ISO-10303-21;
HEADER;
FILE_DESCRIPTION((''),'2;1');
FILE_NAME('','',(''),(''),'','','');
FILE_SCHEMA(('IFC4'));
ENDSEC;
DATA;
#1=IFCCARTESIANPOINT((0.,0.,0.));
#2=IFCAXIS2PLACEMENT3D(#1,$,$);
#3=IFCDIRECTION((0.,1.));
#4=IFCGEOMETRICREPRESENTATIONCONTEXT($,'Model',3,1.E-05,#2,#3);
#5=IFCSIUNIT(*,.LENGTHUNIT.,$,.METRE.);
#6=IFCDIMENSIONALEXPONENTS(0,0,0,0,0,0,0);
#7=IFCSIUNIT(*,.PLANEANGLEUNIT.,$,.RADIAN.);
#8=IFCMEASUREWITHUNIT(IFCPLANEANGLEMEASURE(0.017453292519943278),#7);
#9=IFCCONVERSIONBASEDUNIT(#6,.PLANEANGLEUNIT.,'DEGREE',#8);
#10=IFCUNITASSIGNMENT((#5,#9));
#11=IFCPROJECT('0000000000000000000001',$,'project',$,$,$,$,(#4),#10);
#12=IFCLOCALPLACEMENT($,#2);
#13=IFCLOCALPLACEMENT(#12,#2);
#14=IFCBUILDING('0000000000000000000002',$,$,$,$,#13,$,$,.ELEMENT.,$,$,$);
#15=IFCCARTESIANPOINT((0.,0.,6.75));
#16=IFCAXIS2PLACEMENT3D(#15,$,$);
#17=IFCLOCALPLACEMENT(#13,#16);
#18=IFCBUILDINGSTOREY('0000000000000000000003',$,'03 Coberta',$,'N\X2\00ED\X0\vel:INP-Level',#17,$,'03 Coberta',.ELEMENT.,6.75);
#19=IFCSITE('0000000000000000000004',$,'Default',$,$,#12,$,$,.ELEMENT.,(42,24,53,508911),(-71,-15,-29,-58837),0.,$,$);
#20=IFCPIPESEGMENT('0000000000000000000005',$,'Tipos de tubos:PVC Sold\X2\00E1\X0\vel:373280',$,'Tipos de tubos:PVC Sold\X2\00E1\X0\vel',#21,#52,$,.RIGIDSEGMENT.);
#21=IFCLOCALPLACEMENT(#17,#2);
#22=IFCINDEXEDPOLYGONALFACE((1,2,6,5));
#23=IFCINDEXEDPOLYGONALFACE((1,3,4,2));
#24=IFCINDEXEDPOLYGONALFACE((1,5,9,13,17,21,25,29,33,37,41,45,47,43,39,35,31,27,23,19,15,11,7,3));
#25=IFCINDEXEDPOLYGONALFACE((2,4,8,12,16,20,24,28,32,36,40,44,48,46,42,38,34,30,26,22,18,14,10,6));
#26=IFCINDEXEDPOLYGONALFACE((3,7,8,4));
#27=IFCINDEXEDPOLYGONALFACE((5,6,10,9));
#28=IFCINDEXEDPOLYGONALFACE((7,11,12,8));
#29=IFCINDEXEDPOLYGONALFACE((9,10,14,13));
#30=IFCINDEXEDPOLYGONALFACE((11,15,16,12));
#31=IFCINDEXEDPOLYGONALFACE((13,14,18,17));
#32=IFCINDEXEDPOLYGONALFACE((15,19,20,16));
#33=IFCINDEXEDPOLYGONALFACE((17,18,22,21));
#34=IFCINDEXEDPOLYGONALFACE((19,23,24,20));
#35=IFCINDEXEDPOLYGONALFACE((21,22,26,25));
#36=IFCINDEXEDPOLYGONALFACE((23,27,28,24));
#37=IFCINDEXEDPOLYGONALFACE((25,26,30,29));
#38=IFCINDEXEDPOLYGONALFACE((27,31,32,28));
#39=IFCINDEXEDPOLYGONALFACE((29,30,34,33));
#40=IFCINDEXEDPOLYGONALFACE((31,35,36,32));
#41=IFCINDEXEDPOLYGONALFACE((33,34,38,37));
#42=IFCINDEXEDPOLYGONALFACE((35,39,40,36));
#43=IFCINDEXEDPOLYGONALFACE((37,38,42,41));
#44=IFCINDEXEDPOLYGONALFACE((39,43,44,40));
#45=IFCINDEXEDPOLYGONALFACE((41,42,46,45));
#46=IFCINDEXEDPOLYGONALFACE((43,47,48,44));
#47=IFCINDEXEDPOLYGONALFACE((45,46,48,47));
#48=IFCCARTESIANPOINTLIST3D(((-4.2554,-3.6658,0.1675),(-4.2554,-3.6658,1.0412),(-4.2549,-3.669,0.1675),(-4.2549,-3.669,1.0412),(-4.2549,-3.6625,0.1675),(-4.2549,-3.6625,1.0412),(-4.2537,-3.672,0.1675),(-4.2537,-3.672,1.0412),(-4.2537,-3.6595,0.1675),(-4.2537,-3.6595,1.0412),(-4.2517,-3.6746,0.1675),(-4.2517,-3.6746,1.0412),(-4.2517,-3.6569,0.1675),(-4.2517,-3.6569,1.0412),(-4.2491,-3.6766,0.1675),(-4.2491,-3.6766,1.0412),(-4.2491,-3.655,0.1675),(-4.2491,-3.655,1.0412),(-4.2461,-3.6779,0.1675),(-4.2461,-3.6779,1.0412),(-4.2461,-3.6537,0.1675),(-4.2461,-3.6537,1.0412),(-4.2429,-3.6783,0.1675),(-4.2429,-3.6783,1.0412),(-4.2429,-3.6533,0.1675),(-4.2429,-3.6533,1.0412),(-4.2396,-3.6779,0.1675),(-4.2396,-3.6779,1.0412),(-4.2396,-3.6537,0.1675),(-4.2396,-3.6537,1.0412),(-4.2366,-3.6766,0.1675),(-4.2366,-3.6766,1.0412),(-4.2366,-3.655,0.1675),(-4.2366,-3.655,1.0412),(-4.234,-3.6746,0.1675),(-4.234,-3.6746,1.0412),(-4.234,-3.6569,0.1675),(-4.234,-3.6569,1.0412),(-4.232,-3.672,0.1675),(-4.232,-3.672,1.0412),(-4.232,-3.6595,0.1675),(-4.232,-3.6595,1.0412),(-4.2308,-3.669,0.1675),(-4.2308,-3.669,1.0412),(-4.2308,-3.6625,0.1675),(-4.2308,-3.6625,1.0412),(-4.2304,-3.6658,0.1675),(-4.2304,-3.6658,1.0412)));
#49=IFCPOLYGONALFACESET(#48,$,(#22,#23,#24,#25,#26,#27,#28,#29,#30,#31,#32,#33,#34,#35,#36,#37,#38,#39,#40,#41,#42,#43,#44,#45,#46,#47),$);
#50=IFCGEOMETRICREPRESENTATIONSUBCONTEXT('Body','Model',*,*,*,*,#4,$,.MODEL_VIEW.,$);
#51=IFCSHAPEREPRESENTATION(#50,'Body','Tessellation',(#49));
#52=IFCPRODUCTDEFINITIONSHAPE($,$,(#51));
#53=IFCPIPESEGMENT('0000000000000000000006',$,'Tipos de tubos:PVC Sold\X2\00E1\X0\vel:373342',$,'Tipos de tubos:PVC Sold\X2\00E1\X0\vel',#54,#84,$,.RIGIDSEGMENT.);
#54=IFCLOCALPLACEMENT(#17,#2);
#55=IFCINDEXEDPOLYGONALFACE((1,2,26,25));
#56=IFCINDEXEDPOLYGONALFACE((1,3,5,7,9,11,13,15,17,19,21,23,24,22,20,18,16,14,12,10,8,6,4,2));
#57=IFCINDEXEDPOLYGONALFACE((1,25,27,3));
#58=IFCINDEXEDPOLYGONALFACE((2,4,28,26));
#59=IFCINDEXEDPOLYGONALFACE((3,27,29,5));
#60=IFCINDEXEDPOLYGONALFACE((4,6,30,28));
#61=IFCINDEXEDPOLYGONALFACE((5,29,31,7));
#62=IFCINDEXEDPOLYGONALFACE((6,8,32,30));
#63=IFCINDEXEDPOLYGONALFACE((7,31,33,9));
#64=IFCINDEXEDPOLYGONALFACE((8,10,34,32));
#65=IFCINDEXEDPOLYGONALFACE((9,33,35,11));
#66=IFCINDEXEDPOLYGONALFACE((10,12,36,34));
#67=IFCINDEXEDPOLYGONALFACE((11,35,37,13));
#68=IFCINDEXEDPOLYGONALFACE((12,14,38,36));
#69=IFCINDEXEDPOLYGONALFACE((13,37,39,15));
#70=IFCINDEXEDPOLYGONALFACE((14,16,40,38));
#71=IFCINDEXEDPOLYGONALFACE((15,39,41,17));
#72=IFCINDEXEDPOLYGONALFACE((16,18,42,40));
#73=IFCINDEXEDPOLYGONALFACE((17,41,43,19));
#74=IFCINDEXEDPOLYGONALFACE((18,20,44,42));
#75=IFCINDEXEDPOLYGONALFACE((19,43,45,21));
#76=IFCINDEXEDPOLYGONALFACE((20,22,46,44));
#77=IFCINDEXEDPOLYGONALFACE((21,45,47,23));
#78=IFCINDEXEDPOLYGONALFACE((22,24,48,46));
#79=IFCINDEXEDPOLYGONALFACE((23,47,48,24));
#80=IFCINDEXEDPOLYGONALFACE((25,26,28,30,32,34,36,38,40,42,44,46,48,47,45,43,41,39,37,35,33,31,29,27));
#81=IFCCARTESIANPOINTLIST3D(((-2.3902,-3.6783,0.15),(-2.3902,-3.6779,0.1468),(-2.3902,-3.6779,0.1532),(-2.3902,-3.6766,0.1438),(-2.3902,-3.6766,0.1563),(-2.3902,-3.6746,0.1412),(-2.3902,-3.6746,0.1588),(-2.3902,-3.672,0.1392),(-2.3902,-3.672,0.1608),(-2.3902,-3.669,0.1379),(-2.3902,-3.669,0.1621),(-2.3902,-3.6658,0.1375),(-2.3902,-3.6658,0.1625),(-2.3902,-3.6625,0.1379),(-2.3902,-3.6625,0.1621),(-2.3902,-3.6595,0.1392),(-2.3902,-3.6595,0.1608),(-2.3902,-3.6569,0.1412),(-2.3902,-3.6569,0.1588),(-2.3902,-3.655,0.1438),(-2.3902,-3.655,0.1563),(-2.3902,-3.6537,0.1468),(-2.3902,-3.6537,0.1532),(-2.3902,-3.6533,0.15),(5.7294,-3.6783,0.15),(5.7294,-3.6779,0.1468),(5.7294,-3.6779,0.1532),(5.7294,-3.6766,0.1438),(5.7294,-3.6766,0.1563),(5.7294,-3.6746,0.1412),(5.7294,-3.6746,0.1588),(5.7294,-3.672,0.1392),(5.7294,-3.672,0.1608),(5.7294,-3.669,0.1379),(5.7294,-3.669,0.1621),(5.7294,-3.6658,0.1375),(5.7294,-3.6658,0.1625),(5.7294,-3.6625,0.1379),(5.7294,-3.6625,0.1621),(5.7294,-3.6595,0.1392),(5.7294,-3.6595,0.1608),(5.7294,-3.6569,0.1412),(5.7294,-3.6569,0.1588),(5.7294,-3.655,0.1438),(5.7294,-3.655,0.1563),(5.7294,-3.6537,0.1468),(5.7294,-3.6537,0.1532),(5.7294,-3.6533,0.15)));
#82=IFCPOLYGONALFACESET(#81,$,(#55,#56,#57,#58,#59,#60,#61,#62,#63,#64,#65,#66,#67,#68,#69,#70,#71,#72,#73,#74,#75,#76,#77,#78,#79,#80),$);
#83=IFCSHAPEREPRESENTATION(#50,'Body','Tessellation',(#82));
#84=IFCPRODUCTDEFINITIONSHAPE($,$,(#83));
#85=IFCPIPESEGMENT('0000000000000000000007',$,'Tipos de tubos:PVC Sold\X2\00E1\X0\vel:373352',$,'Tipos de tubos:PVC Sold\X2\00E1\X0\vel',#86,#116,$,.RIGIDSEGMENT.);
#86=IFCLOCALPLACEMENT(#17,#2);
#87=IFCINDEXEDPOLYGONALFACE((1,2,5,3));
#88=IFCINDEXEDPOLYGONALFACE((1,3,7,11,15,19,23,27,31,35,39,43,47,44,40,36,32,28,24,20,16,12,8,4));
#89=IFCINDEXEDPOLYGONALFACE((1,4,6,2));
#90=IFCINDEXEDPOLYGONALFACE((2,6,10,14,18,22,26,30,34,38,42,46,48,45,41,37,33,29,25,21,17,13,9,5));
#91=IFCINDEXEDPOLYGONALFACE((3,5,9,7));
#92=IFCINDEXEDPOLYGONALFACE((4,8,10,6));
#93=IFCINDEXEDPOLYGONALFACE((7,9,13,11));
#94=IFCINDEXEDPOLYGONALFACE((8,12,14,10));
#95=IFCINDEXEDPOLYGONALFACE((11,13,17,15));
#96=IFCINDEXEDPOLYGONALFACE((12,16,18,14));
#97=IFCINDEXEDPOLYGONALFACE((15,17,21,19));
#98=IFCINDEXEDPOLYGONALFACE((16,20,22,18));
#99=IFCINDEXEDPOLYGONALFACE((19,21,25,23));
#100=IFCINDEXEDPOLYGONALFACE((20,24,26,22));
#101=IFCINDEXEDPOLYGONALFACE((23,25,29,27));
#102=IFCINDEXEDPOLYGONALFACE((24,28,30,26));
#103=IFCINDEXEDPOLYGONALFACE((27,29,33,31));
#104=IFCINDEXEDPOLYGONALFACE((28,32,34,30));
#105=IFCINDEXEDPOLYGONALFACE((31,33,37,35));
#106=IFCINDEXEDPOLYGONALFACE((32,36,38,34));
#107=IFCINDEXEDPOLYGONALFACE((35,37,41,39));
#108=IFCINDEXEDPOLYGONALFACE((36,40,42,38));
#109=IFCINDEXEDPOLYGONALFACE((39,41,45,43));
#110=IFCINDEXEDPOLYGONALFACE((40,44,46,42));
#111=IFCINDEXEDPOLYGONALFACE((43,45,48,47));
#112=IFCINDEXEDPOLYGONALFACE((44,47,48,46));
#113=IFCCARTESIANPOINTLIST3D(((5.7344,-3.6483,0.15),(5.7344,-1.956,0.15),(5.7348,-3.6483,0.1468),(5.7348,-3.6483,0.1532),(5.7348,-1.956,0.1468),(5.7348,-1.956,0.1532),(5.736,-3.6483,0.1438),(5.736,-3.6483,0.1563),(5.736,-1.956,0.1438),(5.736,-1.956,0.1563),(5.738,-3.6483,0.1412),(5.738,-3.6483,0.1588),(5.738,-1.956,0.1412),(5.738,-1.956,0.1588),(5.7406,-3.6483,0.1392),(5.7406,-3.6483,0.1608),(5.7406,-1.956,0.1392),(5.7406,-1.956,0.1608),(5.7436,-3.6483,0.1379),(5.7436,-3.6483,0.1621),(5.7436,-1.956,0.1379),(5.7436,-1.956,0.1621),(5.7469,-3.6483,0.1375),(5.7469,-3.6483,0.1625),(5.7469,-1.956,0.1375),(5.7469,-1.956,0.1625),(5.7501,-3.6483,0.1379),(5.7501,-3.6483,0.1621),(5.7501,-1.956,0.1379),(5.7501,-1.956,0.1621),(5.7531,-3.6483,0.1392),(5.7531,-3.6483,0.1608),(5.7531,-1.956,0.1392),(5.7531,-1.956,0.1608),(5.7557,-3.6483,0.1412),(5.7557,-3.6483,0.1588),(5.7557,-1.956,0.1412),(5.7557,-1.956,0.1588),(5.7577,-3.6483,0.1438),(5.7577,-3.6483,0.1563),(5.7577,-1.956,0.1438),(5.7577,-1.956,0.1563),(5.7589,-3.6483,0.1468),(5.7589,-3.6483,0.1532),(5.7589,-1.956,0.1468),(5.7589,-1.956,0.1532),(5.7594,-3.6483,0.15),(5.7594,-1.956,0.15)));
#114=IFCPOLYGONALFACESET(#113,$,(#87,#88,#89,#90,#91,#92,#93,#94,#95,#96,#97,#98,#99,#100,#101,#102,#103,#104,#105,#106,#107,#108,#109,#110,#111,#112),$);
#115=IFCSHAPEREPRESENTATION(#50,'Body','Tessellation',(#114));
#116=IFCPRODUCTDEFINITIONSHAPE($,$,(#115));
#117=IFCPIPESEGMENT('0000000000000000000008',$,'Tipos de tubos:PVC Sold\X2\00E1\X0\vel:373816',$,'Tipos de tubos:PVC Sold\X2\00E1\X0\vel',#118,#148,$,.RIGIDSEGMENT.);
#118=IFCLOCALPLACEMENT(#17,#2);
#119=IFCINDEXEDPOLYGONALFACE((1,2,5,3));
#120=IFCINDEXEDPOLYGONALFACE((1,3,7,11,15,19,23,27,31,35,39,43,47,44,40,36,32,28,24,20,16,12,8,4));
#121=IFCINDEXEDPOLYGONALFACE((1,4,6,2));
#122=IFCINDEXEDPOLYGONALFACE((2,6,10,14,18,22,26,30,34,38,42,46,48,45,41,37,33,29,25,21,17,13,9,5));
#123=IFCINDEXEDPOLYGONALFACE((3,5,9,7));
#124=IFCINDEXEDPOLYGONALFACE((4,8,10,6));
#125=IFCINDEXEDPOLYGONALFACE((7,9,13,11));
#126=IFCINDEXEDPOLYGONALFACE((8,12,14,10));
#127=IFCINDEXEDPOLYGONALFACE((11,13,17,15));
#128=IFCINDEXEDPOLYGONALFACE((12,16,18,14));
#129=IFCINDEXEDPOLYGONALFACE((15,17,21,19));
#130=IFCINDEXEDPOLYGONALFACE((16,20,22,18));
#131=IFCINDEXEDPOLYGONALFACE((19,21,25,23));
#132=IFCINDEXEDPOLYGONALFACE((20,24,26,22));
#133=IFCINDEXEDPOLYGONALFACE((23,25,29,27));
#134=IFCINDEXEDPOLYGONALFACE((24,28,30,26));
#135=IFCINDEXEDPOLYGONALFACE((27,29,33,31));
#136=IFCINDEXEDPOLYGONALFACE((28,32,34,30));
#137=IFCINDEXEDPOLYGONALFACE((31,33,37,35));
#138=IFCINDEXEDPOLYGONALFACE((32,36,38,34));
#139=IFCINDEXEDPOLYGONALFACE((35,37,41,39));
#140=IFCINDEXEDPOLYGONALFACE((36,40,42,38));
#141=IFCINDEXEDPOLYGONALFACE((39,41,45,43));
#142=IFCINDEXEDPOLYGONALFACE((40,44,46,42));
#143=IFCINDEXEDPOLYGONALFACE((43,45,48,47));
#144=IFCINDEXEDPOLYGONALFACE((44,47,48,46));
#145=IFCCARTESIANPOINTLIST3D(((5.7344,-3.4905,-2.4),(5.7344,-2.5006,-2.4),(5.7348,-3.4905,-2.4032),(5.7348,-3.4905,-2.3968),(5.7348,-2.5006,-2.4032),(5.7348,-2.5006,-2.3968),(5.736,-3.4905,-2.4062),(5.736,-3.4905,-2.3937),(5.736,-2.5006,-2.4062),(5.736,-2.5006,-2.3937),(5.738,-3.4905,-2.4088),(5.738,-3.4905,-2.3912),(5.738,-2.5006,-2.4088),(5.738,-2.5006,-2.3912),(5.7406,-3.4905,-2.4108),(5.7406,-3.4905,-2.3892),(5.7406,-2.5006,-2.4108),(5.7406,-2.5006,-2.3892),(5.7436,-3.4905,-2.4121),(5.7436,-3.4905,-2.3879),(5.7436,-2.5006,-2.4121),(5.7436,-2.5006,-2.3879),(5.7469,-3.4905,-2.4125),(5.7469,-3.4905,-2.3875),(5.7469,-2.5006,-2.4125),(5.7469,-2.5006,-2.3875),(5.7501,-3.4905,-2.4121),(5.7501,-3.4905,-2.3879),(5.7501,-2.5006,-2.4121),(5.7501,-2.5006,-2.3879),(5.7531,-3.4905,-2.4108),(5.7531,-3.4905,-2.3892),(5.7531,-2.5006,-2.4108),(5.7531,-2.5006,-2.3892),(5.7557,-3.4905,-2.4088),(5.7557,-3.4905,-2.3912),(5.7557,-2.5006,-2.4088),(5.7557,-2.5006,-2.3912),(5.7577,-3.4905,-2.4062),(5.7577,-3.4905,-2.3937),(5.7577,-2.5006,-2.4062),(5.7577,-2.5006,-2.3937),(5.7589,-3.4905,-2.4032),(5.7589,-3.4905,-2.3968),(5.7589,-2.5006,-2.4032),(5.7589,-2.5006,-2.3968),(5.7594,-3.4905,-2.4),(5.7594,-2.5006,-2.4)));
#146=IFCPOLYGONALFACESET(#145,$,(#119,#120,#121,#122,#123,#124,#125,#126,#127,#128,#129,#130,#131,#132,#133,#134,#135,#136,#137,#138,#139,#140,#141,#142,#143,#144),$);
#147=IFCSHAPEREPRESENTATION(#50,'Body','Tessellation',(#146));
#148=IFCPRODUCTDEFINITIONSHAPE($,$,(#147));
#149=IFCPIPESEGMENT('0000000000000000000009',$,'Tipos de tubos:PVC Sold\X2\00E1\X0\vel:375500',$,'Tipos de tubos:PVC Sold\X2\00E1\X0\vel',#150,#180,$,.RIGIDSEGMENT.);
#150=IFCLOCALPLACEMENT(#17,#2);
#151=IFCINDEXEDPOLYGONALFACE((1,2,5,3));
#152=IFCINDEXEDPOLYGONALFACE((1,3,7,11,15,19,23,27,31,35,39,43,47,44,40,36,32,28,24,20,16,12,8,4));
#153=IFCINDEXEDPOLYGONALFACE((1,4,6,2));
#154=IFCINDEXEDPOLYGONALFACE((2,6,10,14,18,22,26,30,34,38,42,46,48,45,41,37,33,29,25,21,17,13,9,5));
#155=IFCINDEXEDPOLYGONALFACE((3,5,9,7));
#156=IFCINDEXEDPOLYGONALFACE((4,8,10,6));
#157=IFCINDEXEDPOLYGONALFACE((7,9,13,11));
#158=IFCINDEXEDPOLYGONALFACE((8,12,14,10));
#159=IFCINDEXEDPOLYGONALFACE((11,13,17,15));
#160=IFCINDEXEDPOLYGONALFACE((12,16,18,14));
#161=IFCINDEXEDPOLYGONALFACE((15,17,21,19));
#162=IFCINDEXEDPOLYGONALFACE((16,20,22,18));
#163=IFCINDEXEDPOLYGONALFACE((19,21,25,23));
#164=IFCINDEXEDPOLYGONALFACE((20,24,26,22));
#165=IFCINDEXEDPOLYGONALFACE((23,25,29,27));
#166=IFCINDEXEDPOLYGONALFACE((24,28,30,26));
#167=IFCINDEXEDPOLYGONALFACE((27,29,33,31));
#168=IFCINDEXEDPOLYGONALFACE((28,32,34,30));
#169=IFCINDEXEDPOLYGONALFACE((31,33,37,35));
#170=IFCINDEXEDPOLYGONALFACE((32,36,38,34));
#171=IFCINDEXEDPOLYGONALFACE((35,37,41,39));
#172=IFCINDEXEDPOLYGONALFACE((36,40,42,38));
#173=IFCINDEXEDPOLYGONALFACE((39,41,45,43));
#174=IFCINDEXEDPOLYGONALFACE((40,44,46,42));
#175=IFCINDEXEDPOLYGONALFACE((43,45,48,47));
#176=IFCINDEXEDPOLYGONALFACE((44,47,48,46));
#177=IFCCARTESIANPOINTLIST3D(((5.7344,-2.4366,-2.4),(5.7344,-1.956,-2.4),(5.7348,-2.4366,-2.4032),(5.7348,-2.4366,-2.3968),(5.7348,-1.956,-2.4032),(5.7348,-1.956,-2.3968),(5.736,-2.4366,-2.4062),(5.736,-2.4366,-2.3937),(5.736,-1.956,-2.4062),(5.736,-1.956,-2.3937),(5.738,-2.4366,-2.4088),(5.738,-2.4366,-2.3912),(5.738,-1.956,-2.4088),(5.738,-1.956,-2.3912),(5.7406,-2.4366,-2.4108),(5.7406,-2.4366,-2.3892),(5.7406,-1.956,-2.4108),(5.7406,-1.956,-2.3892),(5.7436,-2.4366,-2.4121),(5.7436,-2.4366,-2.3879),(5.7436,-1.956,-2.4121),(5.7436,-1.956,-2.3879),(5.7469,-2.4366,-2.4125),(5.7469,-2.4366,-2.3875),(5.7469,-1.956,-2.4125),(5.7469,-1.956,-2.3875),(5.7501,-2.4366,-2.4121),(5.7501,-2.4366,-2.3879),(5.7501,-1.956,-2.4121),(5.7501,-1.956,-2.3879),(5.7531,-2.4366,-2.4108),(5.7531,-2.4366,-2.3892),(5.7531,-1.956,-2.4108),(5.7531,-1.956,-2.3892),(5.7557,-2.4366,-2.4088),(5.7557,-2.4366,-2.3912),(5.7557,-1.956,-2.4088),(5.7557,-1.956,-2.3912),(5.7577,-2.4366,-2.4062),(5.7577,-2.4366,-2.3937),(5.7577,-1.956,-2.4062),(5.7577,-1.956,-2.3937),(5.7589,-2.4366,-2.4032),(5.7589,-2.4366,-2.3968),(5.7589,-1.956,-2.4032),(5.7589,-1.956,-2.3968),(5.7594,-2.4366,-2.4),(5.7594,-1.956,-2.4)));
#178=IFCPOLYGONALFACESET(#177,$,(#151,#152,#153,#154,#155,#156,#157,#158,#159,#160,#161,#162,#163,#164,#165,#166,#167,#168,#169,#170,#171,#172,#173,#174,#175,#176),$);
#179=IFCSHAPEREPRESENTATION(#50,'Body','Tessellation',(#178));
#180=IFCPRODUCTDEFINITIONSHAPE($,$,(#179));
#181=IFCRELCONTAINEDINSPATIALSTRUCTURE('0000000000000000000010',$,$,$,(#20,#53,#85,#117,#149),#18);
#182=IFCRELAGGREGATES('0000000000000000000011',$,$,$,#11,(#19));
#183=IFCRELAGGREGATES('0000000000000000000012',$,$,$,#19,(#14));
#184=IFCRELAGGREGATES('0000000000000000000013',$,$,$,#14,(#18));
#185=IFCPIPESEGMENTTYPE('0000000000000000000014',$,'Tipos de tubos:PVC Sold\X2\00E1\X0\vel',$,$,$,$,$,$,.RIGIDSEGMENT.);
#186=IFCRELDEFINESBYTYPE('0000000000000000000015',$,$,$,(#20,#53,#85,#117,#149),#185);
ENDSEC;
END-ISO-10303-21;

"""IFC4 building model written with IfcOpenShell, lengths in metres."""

from ifc_helpers import new_model, entity, si_unit, converted_unit, direction, frame, origin, place, context, subcontext, project, spatial, arc, indexed_curve, outline, extrude, type_object, element, save


model = new_model("IFC4")

# Units and contexts
model_context = context("Model", 3, precision=1e-05, world=origin(), true_north=direction((0.0, 1.0)))
body_context = subcontext(model_context, "Body", "Model", "MODEL_VIEW")
ifc_project = project(units=[si_unit("LENGTHUNIT", "METRE"), converted_unit("PLANEANGLEUNIT", "DEGREE", entity("IfcPlaneAngleMeasure", 0.017453292519943278), si_unit("PLANEANGLEUNIT", "RADIAN"), dimensions=[0, 0, 0, 0, 0, 0, 0])], contexts=[model_context])

# Site, building, storey
site_placement = place(None, origin())
site = spatial("IfcSite", under=ifc_project, at=site_placement, Name="Default", CompositionType="ELEMENT", RefLatitude=(42, 24, 53, 508911), RefLongitude=(-71, -15, -29, -58837), RefElevation=0.0)
building_placement = place(site_placement, origin())
building = spatial("IfcBuilding", under=site, at=building_placement, CompositionType="ELEMENT")
storey_placement = place(building_placement, frame((0.0, 0.0, 6.75)))
storey = spatial("IfcBuildingStorey", under=building, at=storey_placement, Name="03 Coberta", ObjectType="Nível:INP-Level", LongName="03 Coberta", CompositionType="ELEMENT", Elevation=6.75)

# Pipe segments
pipe_segment_type = type_object("IfcPipeSegmentType", Name="Tipos de tubos:PVC Soldável", PredefinedType="RIGIDSEGMENT")
pipe_segment_1_placement = place(storey_placement, origin())
element("IfcPipeSegment", 1, at=pipe_segment_1_placement, inside=storey, type_object=pipe_segment_type, Name="Tipos de tubos:PVC Soldável:373280", ObjectType="Tipos de tubos:PVC Soldável", PredefinedType="RIGIDSEGMENT", context=body_context, shape_type="SweptSolid", body=[
    extrude(outline(indexed_curve([(0.0125, 0.0), (0.0088, 0.0088), (0.0, 0.0125), (-0.0088, 0.0088), (-0.0125, 0.0), (-0.0088, -0.0088), (0.0, -0.0125), (0.0088, -0.0088)], segments=[arc(1, 2, 3), arc(3, 4, 5), arc(5, 6, 7), arc(7, 8, 1)], self_intersect=False)), frame((-4.2429, -3.6658, 0.1675)), (0.0, 0.0, 1.0), 0.8737),
])
pipe_segment_2_placement = place(storey_placement, origin())
element("IfcPipeSegment", 2, at=pipe_segment_2_placement, inside=storey, type_object=pipe_segment_type, Name="Tipos de tubos:PVC Soldável:373342", ObjectType="Tipos de tubos:PVC Soldável", PredefinedType="RIGIDSEGMENT", context=body_context, shape_type="SweptSolid", body=[
    extrude(outline(indexed_curve([(0.0125, 0.0), (0.0088, 0.0088), (0.0, 0.0125), (-0.0088, 0.0088), (-0.0125, 0.0), (-0.0088, -0.0088), (0.0, -0.0125), (0.0088, -0.0088)], segments=[arc(1, 2, 3), arc(3, 4, 5), arc(5, 6, 7), arc(7, 8, 1)], self_intersect=False)), frame((-2.3902, -3.6658, 0.15), z_axis=(1.0, 0.0, 0.0), x_axis=(0.0, -1.0, 0.0)), (0.0, 0.0, 1.0), 8.1196),
])
pipe_segment_3_placement = place(storey_placement, origin())
element("IfcPipeSegment", 3, at=pipe_segment_3_placement, inside=storey, type_object=pipe_segment_type, Name="Tipos de tubos:PVC Soldável:373352", ObjectType="Tipos de tubos:PVC Soldável", PredefinedType="RIGIDSEGMENT", context=body_context, shape_type="SweptSolid", body=[
    extrude(outline(indexed_curve([(0.0125, 0.0), (0.0088, 0.0088), (0.0, 0.0125), (-0.0088, 0.0088), (-0.0125, 0.0), (-0.0088, -0.0088), (0.0, -0.0125), (0.0088, -0.0088)], segments=[arc(1, 2, 3), arc(3, 4, 5), arc(5, 6, 7), arc(7, 8, 1)], self_intersect=False)), frame((5.7469, -3.6483, 0.15), z_axis=(0.0, 1.0, 0.0), x_axis=(1.0, 0.0, 0.0)), (0.0, 0.0, 1.0), 1.6922),
])
pipe_segment_4_placement = place(storey_placement, origin())
element("IfcPipeSegment", 4, at=pipe_segment_4_placement, inside=storey, type_object=pipe_segment_type, Name="Tipos de tubos:PVC Soldável:373816", ObjectType="Tipos de tubos:PVC Soldável", PredefinedType="RIGIDSEGMENT", context=body_context, shape_type="SweptSolid", body=[
    extrude(outline(indexed_curve([(0.0125, 0.0), (0.0088, 0.0088), (0.0, 0.0125), (-0.0088, 0.0088), (-0.0125, 0.0), (-0.0088, -0.0088), (0.0, -0.0125), (0.0088, -0.0088)], segments=[arc(1, 2, 3), arc(3, 4, 5), arc(5, 6, 7), arc(7, 8, 1)], self_intersect=False)), frame((5.7469, -3.4905, -2.4), z_axis=(0.0, 1.0, 0.0), x_axis=(-1.0, 0.0, 0.0)), (0.0, 0.0, 1.0), 0.9898),
])
pipe_segment_5_placement = place(storey_placement, origin())
element("IfcPipeSegment", 5, at=pipe_segment_5_placement, inside=storey, type_object=pipe_segment_type, Name="Tipos de tubos:PVC Soldável:375500", ObjectType="Tipos de tubos:PVC Soldável", PredefinedType="RIGIDSEGMENT", context=body_context, shape_type="SweptSolid", body=[
    extrude(outline(indexed_curve([(0.0125, 0.0), (0.0088, 0.0088), (0.0, 0.0125), (-0.0088, 0.0088), (-0.0125, 0.0), (-0.0088, -0.0088), (0.0, -0.0125), (0.0088, -0.0088)], segments=[arc(1, 2, 3), arc(3, 4, 5), arc(5, 6, 7), arc(7, 8, 1)], self_intersect=False)), frame((5.7469, -2.4366, -2.4), z_axis=(0.0, 1.0, 0.0), x_axis=(-1.0, 0.0, 0.0)), (0.0, 0.0, 1.0), 0.4806),
])

save(model, "model.ifc")
